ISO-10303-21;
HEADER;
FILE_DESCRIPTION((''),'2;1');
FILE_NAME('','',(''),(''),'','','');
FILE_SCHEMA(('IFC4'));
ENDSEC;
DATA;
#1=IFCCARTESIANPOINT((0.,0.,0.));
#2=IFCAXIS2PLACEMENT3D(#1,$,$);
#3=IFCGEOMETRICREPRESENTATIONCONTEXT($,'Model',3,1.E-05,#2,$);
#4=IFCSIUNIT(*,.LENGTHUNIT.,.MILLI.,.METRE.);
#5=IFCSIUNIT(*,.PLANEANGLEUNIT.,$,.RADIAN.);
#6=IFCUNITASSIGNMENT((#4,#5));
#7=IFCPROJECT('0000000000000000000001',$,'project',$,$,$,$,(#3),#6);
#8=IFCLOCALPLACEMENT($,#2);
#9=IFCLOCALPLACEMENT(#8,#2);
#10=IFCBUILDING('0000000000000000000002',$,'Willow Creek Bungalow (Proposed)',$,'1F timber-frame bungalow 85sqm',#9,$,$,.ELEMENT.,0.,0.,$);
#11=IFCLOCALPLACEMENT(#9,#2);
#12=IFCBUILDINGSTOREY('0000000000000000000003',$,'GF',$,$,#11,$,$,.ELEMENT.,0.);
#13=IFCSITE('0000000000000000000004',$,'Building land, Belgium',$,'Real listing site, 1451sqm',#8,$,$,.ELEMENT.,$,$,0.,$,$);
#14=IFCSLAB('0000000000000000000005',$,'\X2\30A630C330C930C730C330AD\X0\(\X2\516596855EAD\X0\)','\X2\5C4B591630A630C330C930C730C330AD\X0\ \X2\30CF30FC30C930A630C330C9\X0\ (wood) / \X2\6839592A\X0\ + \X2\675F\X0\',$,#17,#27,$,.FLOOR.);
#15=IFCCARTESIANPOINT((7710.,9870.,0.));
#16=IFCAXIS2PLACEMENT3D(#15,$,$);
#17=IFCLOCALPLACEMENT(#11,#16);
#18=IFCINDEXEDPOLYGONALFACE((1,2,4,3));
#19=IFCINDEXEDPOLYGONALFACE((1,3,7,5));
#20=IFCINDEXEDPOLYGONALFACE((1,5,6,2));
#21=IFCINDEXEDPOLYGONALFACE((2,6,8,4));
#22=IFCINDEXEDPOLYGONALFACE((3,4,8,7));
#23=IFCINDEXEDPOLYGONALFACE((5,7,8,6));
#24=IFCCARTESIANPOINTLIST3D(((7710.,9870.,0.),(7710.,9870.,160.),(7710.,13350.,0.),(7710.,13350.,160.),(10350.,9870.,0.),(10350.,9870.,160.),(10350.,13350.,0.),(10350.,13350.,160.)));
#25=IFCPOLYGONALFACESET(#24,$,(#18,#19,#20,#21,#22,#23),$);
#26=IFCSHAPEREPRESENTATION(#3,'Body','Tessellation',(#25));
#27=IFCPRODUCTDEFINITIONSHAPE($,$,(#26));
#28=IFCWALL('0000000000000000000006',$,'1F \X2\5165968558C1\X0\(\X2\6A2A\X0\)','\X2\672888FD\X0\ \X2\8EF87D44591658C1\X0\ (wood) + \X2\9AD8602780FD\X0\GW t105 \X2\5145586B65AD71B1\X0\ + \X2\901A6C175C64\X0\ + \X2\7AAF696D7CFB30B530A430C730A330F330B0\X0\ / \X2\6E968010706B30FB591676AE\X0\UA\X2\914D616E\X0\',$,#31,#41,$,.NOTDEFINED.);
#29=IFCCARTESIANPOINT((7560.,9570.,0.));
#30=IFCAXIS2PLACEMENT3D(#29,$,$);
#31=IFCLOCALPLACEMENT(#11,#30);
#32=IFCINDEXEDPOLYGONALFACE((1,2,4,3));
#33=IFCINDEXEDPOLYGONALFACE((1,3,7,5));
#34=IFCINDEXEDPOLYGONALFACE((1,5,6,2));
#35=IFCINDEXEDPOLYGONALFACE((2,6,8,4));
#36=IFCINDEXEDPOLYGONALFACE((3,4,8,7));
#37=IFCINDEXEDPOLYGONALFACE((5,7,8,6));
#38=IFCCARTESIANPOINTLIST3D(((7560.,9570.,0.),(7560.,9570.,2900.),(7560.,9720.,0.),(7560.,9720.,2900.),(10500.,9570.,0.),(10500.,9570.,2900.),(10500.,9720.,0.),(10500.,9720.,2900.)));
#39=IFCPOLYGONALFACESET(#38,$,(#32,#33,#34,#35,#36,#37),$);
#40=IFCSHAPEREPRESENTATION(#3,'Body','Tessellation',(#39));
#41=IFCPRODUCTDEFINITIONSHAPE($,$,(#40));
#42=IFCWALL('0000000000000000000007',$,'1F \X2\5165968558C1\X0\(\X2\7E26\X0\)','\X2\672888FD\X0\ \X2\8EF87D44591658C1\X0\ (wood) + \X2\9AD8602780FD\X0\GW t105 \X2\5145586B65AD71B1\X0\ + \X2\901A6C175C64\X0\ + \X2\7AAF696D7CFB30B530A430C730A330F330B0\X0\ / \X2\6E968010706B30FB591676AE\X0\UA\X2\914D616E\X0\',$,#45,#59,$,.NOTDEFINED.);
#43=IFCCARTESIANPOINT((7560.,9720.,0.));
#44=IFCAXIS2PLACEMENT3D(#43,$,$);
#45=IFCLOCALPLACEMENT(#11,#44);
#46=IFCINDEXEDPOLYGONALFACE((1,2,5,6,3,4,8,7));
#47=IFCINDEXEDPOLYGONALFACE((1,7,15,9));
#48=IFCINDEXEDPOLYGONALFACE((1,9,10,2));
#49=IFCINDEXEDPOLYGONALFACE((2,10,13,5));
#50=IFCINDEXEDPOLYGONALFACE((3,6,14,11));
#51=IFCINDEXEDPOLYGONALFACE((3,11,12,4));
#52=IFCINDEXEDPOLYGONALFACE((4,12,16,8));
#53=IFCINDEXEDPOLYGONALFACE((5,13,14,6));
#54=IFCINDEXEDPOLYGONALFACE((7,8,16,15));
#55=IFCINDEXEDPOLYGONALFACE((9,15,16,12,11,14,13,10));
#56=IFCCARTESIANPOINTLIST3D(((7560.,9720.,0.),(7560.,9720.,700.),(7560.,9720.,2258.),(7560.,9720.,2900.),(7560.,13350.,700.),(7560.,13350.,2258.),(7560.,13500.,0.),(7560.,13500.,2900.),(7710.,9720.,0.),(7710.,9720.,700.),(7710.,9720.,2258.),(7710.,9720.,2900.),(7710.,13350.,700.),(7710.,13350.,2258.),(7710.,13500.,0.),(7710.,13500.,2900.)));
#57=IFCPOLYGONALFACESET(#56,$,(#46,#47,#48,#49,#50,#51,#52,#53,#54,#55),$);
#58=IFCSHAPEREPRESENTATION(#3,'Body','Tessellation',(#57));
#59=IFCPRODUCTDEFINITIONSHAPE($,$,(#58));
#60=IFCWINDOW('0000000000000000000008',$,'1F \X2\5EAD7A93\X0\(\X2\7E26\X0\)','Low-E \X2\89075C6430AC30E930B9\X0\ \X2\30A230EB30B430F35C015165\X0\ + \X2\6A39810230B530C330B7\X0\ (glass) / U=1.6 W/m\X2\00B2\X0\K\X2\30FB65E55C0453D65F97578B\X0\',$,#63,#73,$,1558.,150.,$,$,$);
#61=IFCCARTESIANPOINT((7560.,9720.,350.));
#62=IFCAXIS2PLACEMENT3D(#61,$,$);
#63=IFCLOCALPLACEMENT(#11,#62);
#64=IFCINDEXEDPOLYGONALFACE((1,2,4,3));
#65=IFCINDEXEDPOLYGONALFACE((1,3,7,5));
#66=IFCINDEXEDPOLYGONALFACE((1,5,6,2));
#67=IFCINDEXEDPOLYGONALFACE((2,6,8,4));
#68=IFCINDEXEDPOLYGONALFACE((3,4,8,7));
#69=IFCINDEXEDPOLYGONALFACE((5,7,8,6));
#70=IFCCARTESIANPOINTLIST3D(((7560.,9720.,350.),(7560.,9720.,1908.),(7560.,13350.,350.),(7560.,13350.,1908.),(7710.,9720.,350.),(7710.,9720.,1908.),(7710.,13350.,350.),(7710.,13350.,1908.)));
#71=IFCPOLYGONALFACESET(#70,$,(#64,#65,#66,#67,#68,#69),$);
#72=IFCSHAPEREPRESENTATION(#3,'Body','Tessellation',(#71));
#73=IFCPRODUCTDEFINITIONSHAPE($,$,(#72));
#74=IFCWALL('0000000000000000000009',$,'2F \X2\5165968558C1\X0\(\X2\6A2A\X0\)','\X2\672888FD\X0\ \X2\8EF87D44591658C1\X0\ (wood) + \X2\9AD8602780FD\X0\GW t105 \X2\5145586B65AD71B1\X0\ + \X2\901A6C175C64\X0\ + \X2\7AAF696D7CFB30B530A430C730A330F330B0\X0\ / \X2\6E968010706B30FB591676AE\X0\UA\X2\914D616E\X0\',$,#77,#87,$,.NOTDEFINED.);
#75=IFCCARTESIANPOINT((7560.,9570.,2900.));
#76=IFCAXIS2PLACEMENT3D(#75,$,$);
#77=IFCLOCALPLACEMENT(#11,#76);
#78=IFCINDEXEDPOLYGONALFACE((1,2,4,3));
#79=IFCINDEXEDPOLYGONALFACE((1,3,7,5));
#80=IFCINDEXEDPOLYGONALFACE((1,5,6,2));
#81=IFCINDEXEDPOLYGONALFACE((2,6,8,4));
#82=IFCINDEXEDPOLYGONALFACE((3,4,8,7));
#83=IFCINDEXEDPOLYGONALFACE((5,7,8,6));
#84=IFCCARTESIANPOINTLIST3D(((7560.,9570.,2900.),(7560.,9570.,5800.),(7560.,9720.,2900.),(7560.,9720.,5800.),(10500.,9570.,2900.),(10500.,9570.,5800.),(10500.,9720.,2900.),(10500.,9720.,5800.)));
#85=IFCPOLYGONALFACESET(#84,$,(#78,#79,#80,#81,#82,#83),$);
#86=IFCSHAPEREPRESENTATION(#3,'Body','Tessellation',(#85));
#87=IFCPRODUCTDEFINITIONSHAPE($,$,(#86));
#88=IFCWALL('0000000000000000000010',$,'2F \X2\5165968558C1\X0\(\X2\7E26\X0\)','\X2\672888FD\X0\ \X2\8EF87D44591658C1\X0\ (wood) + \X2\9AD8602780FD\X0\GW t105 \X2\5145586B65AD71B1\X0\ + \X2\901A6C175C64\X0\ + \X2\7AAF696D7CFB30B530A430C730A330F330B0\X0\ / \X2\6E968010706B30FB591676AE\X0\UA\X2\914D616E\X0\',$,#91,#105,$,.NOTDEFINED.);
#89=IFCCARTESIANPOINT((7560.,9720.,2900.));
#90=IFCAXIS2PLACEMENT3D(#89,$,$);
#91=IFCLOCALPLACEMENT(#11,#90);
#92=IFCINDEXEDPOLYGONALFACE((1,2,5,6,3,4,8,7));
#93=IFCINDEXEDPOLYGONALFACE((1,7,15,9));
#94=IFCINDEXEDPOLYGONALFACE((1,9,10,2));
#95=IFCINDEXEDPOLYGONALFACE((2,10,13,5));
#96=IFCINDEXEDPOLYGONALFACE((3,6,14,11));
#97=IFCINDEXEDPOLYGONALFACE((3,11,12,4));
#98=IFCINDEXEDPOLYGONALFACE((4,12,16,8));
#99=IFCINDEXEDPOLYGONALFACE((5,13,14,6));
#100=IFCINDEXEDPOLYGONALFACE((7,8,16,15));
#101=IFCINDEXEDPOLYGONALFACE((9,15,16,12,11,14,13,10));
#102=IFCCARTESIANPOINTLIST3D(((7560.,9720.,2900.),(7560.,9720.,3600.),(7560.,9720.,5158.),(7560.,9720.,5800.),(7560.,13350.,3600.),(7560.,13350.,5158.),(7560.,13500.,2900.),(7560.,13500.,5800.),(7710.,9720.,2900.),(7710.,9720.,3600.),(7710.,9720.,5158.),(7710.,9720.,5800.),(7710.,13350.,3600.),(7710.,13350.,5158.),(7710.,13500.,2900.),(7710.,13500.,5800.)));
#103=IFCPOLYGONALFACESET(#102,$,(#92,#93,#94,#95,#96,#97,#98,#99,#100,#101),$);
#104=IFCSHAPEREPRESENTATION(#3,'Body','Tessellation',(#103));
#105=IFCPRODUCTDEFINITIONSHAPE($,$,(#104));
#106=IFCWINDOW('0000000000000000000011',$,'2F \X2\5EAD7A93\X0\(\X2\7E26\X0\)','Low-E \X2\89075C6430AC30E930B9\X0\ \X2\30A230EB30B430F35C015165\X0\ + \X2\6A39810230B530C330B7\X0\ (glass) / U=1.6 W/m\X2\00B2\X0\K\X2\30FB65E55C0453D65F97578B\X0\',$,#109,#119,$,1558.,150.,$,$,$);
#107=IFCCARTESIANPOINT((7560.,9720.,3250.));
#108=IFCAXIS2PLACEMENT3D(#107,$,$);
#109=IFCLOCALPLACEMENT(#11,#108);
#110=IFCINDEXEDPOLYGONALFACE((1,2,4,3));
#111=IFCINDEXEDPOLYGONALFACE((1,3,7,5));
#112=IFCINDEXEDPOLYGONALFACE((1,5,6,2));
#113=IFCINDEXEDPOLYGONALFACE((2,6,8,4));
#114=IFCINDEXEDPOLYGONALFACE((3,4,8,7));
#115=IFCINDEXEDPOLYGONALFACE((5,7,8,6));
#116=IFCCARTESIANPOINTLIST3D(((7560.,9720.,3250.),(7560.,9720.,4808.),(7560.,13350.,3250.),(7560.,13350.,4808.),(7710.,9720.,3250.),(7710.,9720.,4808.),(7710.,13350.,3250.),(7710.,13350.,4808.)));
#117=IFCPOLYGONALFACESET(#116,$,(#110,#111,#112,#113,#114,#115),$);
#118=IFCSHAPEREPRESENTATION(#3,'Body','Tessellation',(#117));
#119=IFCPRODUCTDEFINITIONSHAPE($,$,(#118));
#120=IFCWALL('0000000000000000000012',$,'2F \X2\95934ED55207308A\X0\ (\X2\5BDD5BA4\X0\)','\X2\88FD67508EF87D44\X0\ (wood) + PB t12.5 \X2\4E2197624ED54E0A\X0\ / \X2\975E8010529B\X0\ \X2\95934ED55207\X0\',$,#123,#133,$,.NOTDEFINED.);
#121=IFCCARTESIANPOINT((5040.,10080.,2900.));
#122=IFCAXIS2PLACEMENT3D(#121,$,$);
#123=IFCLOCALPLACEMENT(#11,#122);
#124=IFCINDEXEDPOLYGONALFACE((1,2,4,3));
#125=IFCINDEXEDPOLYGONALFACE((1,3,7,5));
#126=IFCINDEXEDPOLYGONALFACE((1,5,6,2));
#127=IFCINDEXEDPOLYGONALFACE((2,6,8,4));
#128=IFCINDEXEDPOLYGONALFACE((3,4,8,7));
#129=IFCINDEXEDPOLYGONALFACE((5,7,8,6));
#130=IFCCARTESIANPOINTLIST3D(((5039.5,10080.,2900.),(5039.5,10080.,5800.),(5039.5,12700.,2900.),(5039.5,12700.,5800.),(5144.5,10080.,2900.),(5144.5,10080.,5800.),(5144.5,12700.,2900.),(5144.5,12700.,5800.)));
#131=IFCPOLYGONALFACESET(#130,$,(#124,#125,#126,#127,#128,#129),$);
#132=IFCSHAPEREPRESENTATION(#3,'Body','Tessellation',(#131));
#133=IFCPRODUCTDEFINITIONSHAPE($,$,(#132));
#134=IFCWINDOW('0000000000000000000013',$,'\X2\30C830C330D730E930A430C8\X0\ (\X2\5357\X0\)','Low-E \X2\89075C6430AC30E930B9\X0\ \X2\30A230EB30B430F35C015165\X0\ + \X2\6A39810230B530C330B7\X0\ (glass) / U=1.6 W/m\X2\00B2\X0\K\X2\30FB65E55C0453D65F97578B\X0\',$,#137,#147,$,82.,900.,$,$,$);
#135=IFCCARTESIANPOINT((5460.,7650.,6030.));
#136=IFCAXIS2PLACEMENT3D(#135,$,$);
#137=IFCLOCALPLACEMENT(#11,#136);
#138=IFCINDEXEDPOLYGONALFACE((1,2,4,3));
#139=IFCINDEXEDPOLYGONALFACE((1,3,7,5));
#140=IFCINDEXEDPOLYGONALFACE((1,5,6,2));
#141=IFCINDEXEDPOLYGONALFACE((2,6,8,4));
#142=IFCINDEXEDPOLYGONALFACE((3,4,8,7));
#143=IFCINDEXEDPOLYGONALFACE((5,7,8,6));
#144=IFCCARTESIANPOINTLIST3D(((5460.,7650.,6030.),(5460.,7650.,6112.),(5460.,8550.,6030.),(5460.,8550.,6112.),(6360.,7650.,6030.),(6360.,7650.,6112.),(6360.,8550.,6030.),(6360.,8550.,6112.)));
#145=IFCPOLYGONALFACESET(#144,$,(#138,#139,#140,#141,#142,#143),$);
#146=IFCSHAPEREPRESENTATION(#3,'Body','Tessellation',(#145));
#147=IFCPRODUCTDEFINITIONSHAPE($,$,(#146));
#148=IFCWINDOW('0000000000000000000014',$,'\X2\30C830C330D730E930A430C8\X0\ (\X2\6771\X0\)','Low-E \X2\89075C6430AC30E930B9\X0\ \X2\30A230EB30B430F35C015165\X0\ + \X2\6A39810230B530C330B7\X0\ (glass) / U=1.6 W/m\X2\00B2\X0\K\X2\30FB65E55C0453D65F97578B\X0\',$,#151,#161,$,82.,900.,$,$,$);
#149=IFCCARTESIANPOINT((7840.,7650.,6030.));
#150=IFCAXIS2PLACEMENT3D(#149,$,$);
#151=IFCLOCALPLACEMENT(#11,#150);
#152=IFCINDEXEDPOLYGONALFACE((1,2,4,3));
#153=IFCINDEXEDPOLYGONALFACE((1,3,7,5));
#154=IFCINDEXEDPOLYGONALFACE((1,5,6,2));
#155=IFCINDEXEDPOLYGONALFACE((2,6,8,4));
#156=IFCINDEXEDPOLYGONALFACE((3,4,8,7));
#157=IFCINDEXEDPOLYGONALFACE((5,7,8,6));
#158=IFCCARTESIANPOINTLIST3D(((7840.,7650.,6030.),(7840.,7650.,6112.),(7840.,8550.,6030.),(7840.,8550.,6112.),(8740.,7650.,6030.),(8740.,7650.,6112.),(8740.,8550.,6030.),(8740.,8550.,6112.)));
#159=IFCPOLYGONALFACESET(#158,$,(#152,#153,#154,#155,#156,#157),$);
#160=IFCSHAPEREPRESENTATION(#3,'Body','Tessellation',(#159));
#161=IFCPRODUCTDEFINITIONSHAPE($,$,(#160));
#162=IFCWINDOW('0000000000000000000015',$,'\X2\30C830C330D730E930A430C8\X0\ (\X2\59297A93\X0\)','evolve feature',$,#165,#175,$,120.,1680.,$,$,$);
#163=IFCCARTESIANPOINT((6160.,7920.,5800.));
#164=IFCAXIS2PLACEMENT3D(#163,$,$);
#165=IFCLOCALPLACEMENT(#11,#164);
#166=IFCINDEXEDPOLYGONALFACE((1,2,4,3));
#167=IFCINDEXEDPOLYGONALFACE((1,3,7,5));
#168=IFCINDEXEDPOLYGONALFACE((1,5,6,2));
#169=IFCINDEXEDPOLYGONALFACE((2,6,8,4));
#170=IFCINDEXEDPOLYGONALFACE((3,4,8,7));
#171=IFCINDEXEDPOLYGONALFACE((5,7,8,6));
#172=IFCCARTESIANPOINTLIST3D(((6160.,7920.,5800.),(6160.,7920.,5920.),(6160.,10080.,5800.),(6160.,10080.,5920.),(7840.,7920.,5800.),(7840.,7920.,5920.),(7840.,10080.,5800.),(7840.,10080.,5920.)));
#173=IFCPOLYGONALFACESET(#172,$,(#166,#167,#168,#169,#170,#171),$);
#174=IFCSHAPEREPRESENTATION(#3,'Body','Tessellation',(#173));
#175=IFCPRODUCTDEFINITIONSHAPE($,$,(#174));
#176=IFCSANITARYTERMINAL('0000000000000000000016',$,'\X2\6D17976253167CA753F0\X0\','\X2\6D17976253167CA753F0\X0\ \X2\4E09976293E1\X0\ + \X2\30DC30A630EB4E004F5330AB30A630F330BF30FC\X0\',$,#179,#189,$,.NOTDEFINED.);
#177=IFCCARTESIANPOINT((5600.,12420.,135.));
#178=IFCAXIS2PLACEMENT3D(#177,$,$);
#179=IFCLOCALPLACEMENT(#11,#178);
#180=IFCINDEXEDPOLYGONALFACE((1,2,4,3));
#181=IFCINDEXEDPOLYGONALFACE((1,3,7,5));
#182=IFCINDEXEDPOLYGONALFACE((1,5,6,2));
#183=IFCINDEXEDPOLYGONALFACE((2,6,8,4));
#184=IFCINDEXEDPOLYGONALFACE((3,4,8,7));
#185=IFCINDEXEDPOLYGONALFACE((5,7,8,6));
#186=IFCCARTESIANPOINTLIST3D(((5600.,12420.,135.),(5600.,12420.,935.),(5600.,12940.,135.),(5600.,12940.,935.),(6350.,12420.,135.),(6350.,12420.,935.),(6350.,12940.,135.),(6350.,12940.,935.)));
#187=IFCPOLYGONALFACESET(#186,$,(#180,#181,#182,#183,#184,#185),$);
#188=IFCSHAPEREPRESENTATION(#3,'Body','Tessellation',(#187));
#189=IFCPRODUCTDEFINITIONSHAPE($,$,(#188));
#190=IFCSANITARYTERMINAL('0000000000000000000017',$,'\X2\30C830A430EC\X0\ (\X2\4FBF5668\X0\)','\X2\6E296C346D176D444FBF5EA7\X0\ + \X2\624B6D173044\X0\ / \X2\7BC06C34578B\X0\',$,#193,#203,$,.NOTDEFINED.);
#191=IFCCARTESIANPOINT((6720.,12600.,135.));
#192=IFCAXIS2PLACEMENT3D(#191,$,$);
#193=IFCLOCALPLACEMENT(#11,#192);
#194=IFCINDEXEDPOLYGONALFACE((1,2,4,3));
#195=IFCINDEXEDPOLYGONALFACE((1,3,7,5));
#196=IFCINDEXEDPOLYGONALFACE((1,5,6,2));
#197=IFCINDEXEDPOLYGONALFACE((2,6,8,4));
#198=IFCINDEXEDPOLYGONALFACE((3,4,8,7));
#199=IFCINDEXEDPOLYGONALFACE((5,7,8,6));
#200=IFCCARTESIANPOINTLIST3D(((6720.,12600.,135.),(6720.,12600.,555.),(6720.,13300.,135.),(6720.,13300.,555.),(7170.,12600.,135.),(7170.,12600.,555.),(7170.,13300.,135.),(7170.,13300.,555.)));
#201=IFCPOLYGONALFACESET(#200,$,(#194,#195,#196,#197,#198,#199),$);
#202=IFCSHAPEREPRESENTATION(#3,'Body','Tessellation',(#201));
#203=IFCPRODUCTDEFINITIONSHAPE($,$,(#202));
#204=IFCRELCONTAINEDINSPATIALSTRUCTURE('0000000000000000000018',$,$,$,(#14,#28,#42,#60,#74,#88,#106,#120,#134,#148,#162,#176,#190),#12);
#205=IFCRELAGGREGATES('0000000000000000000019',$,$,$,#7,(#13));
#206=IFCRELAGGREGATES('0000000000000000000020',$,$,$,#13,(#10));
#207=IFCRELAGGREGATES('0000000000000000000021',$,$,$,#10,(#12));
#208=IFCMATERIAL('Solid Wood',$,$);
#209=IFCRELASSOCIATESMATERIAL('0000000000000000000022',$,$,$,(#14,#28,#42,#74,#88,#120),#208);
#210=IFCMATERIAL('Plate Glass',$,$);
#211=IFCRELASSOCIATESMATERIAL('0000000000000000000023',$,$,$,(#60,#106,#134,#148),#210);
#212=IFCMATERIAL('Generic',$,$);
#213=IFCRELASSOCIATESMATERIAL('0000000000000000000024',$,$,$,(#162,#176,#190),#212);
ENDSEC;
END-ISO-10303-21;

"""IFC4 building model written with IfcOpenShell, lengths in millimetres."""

from ifc_helpers import new_model, si_unit, frame, frame_2d, origin, place, context, project, spatial, rectangle, extrude, material, element, fill, save


model = new_model("IFC4")

# Units and contexts
model_context = context("Model", 3, precision=1e-05, world=origin())
ifc_project = project(units=[si_unit("LENGTHUNIT", "METRE", prefix="MILLI"), si_unit("PLANEANGLEUNIT", "RADIAN")], contexts=[model_context])

# Site, building, storey
site_placement = place(None, origin())
site = spatial("IfcSite", under=ifc_project, at=site_placement, Name="Building land, Belgium", ObjectType="Real listing site, 1451sqm", CompositionType="ELEMENT", RefElevation=0.0)
building_placement = place(site_placement, origin())
building = spatial("IfcBuilding", under=site, at=building_placement, Name="Willow Creek Bungalow (Proposed)", ObjectType="1F timber-frame bungalow 85sqm", CompositionType="ELEMENT", ElevationOfRefHeight=0.0, ElevationOfTerrain=0.0)
storey_placement = place(building_placement, origin())
storey = spatial("IfcBuildingStorey", under=building, at=storey_placement, Name="GF", CompositionType="ELEMENT", Elevation=0.0)

# Slab
ifc_material_1 = material(Name="Solid Wood")
slab_placement = place(storey_placement, frame((7710.0, 9870.0, 0.0)))
element("IfcSlab", 1, at=slab_placement, inside=storey, material=ifc_material_1, Name="ウッドデッキ(入隅庭)", Description="屋外ウッドデッキ ハードウッド (wood) / 根太 + 束", PredefinedType="FLOOR", context=model_context, shape_type="SweptSolid", body=[
    extrude(rectangle(XDim=2640.0, YDim=3480.0, at=frame_2d((1320.0, 1740.0))), frame((7710.0, 9870.0, 0.0)), (0.0, 0.0, 1.0), 160.0),
])

# Wall
wall_1_placement = place(storey_placement, frame((7560.0, 9570.0, 0.0)))
element("IfcWall", 2, at=wall_1_placement, inside=storey, material=ifc_material_1, Name="1F 入隅壁(横)", Description="木製 軸組外壁 (wood) + 高性能GW t105 充填断熱 + 通気層 + 窯業系サイディング / 準耐火・外皮UA配慮", PredefinedType="NOTDEFINED", context=model_context, shape_type="SweptSolid", body=[
    extrude(rectangle(XDim=2940.0, YDim=150.0, at=frame_2d((1470.0, 75.0))), frame((7560.0, 9570.0, 0.0)), (0.0, 0.0, 1.0), 2900.0),
])

# Wall, opening, window
wall_2_placement = place(storey_placement, frame((7560.0, 9720.0, 0.0)))
wall_2 = element("IfcWall", 3, at=wall_2_placement, inside=storey, material=ifc_material_1, Name="1F 入隅壁(縦)", Description="木製 軸組外壁 (wood) + 高性能GW t105 充填断熱 + 通気層 + 窯業系サイディング / 準耐火・外皮UA配慮", PredefinedType="NOTDEFINED", context=model_context, shape_type="SweptSolid", body=[
    extrude(rectangle(XDim=150.0, YDim=3780.0, at=frame_2d((75.0, 1890.0))), frame((7560.0, 9720.0, 0.0)), (0.0, 0.0, 1.0), 2900.0),
])
opening_1_placement = place(storey_placement, frame((7560.0, 9720.0, 350.0)))
opening_1 = element("IfcOpeningElement", 4, at=opening_1_placement, cuts=wall_2, PredefinedType="NOTDEFINED", context=model_context, shape_type="SweptSolid", body=[
    extrude(rectangle(XDim=150.0, YDim=3630.0, at=frame_2d((75.0, 1815.0))), frame((7560.0, 9720.0, 350.0)), (0.0, 0.0, 1.0), 1558.0),
])
ifc_material_2 = material(Name="Plate Glass")
window_1_placement = place(storey_placement, frame((7560.0, 9720.0, 350.0)))
window_1 = element("IfcWindow", 5, at=window_1_placement, inside=storey, material=ifc_material_2, Name="1F 庭窓(縦)", Description="Low-E 複層ガラス アルゴン封入 + 樹脂サッシ (glass) / U=1.6 W/m²K・日射取得型", OverallHeight=1558.0, OverallWidth=150.0, context=model_context, shape_type="SweptSolid", body=[
    extrude(rectangle(XDim=150.0, YDim=3630.0, at=frame_2d((75.0, 1815.0))), frame((7560.0, 9720.0, 350.0)), (0.0, 0.0, 1.0), 1558.0),
])
fill(opening_1, window_1)

# Wall
wall_3_placement = place(storey_placement, frame((7560.0, 9570.0, 2900.0)))
element("IfcWall", 6, at=wall_3_placement, inside=storey, material=ifc_material_1, Name="2F 入隅壁(横)", Description="木製 軸組外壁 (wood) + 高性能GW t105 充填断熱 + 通気層 + 窯業系サイディング / 準耐火・外皮UA配慮", PredefinedType="NOTDEFINED", context=model_context, shape_type="SweptSolid", body=[
    extrude(rectangle(XDim=2940.0, YDim=150.0, at=frame_2d((1470.0, 75.0))), frame((7560.0, 9570.0, 2900.0)), (0.0, 0.0, 1.0), 2900.0),
])

# Wall, opening, window
wall_4_placement = place(storey_placement, frame((7560.0, 9720.0, 2900.0)))
wall_4 = element("IfcWall", 7, at=wall_4_placement, inside=storey, material=ifc_material_1, Name="2F 入隅壁(縦)", Description="木製 軸組外壁 (wood) + 高性能GW t105 充填断熱 + 通気層 + 窯業系サイディング / 準耐火・外皮UA配慮", PredefinedType="NOTDEFINED", context=model_context, shape_type="SweptSolid", body=[
    extrude(rectangle(XDim=150.0, YDim=3780.0, at=frame_2d((75.0, 1890.0))), frame((7560.0, 9720.0, 2900.0)), (0.0, 0.0, 1.0), 2900.0),
])
opening_2_placement = place(storey_placement, frame((7560.0, 9720.0, 3250.0)))
opening_2 = element("IfcOpeningElement", 8, at=opening_2_placement, cuts=wall_4, PredefinedType="NOTDEFINED", context=model_context, shape_type="SweptSolid", body=[
    extrude(rectangle(XDim=150.0, YDim=3630.0, at=frame_2d((75.0, 1815.0))), frame((7560.0, 9720.0, 3250.0)), (0.0, 0.0, 1.0), 1558.0),
])
window_2_placement = place(storey_placement, frame((7560.0, 9720.0, 3250.0)))
window_2 = element("IfcWindow", 9, at=window_2_placement, inside=storey, material=ifc_material_2, Name="2F 庭窓(縦)", Description="Low-E 複層ガラス アルゴン封入 + 樹脂サッシ (glass) / U=1.6 W/m²K・日射取得型", OverallHeight=1558.0, OverallWidth=150.0, context=model_context, shape_type="SweptSolid", body=[
    extrude(rectangle(XDim=150.0, YDim=3630.0, at=frame_2d((75.0, 1815.0))), frame((7560.0, 9720.0, 3250.0)), (0.0, 0.0, 1.0), 1558.0),
])
fill(opening_2, window_2)

# Wall
wall_5_placement = place(storey_placement, frame((5040.0, 10080.0, 2900.0)))
element("IfcWall", 10, at=wall_5_placement, inside=storey, material=ifc_material_1, Name="2F 間仕切り (寝室)", Description="製材軸組 (wood) + PB t12.5 両面仕上 / 非耐力 間仕切", PredefinedType="NOTDEFINED", context=model_context, shape_type="SweptSolid", body=[
    extrude(rectangle(XDim=105.0, YDim=2620.0, at=frame_2d((52.0, 1310.0))), frame((5040.0, 10080.0, 2900.0)), (0.0, 0.0, 1.0), 2900.0),
])

# Windows
window_3_placement = place(storey_placement, frame((5460.0, 7650.0, 6030.0)))
element("IfcWindow", 11, at=window_3_placement, inside=storey, material=ifc_material_2, Name="トップライト (南)", Description="Low-E 複層ガラス アルゴン封入 + 樹脂サッシ (glass) / U=1.6 W/m²K・日射取得型", OverallHeight=82.0, OverallWidth=900.0, context=model_context, shape_type="SweptSolid", body=[
    extrude(rectangle(XDim=900.0, YDim=900.0, at=frame_2d((450.0, 450.0))), frame((5460.0, 7650.0, 6030.0)), (0.0, 0.0, 1.0), 82.0),
])
window_4_placement = place(storey_placement, frame((7840.0, 7650.0, 6030.0)))
element("IfcWindow", 12, at=window_4_placement, inside=storey, material=ifc_material_2, Name="トップライト (東)", Description="Low-E 複層ガラス アルゴン封入 + 樹脂サッシ (glass) / U=1.6 W/m²K・日射取得型", OverallHeight=82.0, OverallWidth=900.0, context=model_context, shape_type="SweptSolid", body=[
    extrude(rectangle(XDim=900.0, YDim=900.0, at=frame_2d((450.0, 450.0))), frame((7840.0, 7650.0, 6030.0)), (0.0, 0.0, 1.0), 82.0),
])
ifc_material_3 = material(Name="Generic")
window_5_placement = place(storey_placement, frame((6160.0, 7920.0, 5800.0)))
element("IfcWindow", 13, at=window_5_placement, inside=storey, material=ifc_material_3, Name="トップライト (天窓)", Description="evolve feature", OverallHeight=120.0, OverallWidth=1680.0, context=model_context, shape_type="SweptSolid", body=[
    extrude(rectangle(XDim=1680.0, YDim=2160.0, at=frame_2d((840.0, 1080.0))), frame((6160.0, 7920.0, 5800.0)), (0.0, 0.0, 1.0), 120.0),
])

# Sanitary terminals
sanitary_terminal_1_placement = place(storey_placement, frame((5600.0, 12420.0, 135.0)))
element("IfcSanitaryTerminal", 14, at=sanitary_terminal_1_placement, inside=storey, material=ifc_material_3, Name="洗面化粧台", Description="洗面化粧台 三面鏡 + ボウル一体カウンター", PredefinedType="NOTDEFINED", context=model_context, shape_type="SweptSolid", body=[
    extrude(rectangle(XDim=750.0, YDim=520.0, at=frame_2d((375.0, 260.0))), frame((5600.0, 12420.0, 135.0)), (0.0, 0.0, 1.0), 800.0),
])
sanitary_terminal_2_placement = place(storey_placement, frame((6720.0, 12600.0, 135.0)))
element("IfcSanitaryTerminal", 15, at=sanitary_terminal_2_placement, inside=storey, material=ifc_material_3, Name="トイレ (便器)", Description="温水洗浄便座 + 手洗い / 節水型", PredefinedType="NOTDEFINED", context=model_context, shape_type="SweptSolid", body=[
    extrude(rectangle(XDim=450.0, YDim=700.0, at=frame_2d((225.0, 350.0))), frame((6720.0, 12600.0, 135.0)), (0.0, 0.0, 1.0), 420.0),
])

save(model, "model.ifc")
